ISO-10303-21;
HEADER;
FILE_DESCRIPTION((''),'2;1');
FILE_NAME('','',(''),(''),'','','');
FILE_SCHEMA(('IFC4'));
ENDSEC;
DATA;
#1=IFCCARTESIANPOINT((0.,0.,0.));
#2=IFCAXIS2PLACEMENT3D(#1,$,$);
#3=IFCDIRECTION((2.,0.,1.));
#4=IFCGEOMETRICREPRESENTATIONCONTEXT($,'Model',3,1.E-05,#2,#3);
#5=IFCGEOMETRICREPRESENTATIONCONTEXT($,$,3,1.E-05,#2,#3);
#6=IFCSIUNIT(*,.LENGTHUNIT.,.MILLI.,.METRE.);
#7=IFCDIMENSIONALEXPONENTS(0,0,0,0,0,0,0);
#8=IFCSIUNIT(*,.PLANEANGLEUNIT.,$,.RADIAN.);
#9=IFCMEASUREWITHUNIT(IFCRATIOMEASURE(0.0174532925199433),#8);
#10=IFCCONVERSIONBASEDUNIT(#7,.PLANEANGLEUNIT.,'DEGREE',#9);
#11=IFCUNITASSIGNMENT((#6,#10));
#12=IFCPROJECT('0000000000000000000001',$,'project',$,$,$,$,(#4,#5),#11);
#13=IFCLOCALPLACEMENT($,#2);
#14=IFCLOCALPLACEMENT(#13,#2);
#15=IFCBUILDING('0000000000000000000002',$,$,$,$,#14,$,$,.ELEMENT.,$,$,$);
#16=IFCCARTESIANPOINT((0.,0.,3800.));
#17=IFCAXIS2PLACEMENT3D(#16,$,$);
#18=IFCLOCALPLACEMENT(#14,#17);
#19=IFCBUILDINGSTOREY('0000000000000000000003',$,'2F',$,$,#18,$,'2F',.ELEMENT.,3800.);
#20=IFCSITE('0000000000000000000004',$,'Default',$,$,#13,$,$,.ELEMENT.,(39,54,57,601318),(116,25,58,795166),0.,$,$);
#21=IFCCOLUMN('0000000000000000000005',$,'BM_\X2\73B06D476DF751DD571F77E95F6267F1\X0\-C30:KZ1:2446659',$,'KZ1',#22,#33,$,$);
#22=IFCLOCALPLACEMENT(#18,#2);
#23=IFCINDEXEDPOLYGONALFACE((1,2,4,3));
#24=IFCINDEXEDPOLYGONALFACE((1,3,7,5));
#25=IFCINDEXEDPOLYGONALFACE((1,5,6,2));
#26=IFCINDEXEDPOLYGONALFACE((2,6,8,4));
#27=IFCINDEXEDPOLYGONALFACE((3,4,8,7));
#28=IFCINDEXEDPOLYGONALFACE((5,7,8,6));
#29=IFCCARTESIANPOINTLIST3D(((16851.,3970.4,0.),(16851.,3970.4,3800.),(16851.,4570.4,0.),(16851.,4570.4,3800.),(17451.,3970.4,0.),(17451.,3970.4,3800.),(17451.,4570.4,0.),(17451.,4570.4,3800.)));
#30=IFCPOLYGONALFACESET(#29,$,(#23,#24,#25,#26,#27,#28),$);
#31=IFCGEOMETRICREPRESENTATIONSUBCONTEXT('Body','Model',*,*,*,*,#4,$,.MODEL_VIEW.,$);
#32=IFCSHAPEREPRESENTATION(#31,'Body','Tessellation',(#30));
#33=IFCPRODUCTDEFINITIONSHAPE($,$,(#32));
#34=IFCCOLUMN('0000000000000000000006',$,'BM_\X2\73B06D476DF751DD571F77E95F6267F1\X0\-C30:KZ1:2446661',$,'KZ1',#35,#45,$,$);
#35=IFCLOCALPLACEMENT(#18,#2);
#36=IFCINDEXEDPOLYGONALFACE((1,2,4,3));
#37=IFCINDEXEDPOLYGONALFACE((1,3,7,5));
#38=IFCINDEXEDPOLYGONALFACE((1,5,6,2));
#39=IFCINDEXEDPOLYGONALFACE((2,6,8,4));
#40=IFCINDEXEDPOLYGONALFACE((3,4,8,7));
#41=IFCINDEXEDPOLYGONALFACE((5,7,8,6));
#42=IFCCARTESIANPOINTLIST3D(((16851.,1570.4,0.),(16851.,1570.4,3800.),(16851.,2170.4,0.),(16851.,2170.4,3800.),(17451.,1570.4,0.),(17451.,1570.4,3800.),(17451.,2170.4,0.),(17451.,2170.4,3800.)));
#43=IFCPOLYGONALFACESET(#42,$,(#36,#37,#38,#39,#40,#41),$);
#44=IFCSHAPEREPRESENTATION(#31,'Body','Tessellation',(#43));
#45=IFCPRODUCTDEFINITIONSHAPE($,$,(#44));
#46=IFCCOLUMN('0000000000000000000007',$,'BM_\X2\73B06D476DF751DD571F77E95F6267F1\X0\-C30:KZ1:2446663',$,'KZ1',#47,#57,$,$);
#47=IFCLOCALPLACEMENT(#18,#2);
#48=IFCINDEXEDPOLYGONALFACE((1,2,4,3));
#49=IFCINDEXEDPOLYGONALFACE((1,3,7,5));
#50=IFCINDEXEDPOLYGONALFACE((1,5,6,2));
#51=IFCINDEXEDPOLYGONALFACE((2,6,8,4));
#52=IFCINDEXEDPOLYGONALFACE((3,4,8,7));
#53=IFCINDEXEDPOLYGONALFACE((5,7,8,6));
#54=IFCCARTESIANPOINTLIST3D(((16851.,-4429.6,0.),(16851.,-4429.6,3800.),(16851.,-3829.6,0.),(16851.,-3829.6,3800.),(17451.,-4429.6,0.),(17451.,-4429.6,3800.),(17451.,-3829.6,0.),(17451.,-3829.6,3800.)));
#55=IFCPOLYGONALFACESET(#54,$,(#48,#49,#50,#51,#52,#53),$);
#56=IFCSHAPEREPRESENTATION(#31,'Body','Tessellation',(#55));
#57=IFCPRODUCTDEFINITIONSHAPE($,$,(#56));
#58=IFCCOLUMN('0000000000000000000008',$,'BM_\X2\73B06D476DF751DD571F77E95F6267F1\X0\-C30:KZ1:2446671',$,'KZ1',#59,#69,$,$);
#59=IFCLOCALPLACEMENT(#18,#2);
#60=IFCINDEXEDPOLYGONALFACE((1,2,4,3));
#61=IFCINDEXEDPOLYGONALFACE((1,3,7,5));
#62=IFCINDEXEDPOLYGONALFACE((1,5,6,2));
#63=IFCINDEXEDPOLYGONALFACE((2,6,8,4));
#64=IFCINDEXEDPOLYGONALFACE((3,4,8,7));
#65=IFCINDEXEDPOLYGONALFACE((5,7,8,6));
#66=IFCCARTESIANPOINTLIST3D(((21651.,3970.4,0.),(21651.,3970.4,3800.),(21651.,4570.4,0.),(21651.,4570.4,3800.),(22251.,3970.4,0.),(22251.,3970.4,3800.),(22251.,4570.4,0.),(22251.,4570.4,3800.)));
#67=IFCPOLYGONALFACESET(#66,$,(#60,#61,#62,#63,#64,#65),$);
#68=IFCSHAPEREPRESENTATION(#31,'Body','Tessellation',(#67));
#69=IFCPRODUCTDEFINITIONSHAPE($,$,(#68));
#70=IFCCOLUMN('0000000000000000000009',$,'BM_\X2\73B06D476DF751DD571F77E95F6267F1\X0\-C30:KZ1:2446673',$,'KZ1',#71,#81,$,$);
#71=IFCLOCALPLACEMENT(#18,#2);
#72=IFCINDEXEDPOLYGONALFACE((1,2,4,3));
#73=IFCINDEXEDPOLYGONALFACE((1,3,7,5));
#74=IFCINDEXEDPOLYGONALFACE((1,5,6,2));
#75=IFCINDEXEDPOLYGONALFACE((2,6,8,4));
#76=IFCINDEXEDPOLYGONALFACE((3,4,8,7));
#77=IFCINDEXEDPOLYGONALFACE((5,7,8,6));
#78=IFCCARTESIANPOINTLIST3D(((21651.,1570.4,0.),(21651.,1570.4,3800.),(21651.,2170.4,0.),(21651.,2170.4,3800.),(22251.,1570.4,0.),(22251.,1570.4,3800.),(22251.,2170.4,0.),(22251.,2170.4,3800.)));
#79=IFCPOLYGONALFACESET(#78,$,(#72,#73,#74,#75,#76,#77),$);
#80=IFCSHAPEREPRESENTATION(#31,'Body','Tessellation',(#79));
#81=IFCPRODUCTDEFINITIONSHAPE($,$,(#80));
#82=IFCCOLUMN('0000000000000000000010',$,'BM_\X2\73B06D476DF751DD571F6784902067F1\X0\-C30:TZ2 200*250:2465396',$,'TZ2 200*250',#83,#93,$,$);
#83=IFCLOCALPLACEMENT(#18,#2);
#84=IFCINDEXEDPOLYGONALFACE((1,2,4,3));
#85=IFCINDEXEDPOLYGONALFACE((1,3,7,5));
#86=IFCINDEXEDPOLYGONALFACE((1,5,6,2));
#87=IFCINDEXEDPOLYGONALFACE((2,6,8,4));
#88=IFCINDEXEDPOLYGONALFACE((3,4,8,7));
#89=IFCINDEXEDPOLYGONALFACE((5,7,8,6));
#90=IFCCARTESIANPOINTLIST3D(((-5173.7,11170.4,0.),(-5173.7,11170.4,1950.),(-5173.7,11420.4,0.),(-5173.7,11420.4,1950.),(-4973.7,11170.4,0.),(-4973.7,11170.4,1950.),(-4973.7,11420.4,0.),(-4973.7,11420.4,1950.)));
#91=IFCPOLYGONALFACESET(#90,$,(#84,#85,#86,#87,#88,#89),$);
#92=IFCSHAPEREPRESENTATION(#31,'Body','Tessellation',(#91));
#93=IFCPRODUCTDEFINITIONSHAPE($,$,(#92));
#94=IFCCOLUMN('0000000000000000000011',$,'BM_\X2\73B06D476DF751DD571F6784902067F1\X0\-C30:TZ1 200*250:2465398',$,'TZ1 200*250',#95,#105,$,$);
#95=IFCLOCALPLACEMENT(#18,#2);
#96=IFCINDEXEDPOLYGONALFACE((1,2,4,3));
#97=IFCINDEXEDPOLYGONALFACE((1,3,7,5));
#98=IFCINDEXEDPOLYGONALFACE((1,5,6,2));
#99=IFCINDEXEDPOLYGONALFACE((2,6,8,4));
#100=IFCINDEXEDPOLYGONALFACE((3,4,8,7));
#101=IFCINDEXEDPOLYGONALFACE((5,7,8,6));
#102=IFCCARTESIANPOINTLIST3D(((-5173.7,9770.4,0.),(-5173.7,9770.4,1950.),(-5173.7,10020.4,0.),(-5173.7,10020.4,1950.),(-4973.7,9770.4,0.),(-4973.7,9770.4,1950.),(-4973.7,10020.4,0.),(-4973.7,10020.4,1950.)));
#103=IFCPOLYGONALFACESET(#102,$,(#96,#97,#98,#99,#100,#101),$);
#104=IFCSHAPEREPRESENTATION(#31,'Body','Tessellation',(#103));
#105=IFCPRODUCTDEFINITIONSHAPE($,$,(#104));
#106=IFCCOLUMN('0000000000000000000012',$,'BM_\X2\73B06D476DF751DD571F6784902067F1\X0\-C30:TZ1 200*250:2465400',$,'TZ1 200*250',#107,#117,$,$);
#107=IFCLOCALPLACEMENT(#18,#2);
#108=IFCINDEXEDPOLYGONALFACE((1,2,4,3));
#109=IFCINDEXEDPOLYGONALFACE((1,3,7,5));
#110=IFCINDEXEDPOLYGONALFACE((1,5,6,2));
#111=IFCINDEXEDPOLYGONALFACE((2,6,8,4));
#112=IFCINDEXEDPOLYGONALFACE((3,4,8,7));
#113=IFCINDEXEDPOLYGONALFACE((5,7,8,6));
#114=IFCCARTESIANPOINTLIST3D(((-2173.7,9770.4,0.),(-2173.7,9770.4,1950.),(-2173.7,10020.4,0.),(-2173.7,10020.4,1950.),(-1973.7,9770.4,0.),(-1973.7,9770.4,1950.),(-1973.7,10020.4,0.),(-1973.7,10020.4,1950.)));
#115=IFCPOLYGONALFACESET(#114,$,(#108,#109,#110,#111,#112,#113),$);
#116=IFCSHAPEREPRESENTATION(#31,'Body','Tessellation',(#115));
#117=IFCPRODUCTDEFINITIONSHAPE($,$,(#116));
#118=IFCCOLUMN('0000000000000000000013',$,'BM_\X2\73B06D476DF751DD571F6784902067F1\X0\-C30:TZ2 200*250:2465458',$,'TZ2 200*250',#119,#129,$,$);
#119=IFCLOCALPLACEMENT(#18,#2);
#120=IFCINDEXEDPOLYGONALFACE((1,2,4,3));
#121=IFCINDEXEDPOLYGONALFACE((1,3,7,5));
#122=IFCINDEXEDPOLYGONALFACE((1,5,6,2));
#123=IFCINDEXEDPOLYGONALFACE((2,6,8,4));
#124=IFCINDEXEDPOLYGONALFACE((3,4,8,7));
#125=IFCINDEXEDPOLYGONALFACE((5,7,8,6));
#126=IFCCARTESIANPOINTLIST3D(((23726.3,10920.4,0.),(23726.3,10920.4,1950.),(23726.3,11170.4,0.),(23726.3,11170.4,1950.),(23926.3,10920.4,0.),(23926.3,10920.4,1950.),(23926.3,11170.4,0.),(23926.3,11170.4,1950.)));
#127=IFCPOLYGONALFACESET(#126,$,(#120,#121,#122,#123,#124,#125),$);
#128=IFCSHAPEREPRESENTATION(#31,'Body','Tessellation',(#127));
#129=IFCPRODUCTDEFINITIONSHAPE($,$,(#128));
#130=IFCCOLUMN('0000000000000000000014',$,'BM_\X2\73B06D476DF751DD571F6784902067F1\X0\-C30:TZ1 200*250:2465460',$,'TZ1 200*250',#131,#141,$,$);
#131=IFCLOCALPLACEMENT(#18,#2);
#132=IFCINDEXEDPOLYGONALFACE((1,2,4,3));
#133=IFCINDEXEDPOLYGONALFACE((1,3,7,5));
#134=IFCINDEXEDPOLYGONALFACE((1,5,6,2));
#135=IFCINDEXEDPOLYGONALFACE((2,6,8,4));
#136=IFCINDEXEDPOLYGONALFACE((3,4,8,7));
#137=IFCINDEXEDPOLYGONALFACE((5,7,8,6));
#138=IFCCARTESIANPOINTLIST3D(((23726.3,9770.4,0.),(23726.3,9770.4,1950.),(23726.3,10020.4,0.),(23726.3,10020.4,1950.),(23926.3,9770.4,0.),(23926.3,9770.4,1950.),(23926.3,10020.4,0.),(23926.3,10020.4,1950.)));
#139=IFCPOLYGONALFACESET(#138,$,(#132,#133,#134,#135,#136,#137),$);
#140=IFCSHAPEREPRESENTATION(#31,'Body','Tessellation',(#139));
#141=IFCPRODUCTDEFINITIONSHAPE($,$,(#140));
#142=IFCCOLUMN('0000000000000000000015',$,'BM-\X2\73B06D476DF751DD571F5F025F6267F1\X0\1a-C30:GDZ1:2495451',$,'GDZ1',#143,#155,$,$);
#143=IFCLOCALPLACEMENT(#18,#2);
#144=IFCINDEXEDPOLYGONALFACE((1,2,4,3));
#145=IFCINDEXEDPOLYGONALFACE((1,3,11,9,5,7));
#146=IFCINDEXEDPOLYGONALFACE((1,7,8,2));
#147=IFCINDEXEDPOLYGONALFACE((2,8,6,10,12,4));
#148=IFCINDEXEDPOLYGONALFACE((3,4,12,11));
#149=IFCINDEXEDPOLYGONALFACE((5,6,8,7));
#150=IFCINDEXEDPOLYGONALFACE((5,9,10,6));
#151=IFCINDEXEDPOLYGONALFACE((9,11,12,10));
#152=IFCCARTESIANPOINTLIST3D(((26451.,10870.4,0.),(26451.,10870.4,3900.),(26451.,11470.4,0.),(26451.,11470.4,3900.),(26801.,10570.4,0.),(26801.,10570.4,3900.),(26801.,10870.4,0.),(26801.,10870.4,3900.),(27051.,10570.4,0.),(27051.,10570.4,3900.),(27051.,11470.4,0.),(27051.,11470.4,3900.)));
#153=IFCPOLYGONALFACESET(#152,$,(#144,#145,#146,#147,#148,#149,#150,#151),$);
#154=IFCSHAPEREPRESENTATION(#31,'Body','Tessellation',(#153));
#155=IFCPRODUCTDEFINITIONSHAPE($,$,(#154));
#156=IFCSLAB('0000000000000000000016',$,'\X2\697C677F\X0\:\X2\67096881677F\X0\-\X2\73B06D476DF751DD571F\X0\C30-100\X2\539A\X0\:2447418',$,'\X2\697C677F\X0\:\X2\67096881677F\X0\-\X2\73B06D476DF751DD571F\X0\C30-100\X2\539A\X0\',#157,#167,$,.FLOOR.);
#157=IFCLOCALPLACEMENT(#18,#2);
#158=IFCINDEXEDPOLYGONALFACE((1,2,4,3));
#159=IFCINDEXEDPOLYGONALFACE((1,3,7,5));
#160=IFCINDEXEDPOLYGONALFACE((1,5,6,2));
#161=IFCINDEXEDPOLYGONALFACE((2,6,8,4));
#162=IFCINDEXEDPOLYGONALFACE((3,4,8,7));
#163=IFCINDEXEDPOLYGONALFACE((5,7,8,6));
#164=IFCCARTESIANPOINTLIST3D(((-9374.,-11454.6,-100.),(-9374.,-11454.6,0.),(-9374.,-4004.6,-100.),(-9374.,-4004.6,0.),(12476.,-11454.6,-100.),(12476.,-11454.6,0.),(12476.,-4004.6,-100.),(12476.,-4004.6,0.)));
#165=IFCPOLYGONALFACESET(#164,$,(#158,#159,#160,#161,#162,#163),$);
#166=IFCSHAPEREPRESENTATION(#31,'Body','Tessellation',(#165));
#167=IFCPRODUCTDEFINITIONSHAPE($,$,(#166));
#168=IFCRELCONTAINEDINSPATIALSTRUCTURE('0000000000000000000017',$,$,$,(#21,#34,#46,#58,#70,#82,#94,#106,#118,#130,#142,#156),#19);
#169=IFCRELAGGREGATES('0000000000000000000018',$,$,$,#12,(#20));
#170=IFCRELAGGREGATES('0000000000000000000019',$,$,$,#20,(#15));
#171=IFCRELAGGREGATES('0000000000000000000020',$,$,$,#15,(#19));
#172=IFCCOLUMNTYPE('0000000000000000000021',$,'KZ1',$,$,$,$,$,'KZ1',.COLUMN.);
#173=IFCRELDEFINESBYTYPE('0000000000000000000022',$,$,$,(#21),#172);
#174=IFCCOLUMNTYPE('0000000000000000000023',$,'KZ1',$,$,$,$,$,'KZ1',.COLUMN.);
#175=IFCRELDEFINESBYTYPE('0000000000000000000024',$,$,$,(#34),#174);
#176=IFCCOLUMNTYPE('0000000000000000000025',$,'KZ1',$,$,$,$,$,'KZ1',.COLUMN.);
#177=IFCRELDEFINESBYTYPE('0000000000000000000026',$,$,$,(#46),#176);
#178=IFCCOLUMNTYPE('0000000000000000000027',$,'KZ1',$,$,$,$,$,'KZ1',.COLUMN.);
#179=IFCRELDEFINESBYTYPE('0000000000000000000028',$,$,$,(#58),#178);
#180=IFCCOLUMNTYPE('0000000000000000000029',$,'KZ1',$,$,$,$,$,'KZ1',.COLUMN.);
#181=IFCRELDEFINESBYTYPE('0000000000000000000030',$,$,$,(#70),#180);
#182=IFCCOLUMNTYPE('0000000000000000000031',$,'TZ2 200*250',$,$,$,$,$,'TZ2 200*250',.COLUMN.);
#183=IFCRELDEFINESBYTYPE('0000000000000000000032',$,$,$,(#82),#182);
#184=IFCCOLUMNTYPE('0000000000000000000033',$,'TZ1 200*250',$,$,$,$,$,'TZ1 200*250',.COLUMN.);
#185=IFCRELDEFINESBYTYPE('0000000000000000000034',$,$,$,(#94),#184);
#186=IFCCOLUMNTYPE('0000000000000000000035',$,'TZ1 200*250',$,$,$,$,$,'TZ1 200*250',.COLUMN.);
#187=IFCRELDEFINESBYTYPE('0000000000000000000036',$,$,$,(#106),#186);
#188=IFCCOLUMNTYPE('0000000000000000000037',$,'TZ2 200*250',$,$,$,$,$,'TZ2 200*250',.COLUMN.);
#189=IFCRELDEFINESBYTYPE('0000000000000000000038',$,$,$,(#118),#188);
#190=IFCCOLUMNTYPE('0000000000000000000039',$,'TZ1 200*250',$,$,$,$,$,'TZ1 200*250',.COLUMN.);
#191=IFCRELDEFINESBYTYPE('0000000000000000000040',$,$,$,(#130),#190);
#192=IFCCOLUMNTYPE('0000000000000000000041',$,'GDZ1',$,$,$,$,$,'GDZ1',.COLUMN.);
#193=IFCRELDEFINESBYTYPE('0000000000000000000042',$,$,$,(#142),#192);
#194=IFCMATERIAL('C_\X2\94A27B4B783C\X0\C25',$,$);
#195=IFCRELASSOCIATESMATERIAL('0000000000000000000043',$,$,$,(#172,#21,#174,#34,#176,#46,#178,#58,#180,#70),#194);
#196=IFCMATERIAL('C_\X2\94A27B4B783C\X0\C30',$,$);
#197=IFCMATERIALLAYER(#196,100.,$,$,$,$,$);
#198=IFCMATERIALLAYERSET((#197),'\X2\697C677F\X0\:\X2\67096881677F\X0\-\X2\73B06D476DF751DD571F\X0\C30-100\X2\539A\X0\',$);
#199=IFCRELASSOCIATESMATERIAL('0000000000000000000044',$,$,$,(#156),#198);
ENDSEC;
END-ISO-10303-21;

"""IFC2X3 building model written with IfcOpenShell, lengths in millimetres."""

from ifc_helpers import new_model, entity, si_unit, converted_unit, direction, frame, frame_2d, origin, place, context, subcontext, project, spatial, polyline, rectangle, outline, extrude, source, transform, mapped, material, layer, layer_set, layer_usage, type_object, type_shapes, element, save


model = new_model("IFC2X3")

# Units and contexts
model_context = context("Model", 3, precision=1e-05, world=origin(), true_north=direction((2.0, 0.0, 1.0)))
context_of_model = context(None, 3, precision=1e-05, world=origin(), true_north=direction((2.0, 0.0, 1.0)))
body_context = subcontext(model_context, "Body", "Model", "MODEL_VIEW")
ifc_project = project(units=[si_unit("LENGTHUNIT", "METRE", prefix="MILLI"), converted_unit("PLANEANGLEUNIT", "DEGREE", entity("IfcRatioMeasure", 0.0174532925199433), si_unit("PLANEANGLEUNIT", "RADIAN"), dimensions=[0, 0, 0, 0, 0, 0, 0])], contexts=[model_context, context_of_model])

# Site, building, storey
site_placement = place(None, origin())
site = spatial("IfcSite", under=ifc_project, at=site_placement, Name="Default", CompositionType="ELEMENT", RefLatitude=(39, 54, 57, 601318), RefLongitude=(116, 25, 58, 795166), RefElevation=0.0)
building_placement = place(site_placement, origin())
building = spatial("IfcBuilding", under=site, at=building_placement, CompositionType="ELEMENT")
storey_placement = place(building_placement, frame((0.0, 0.0, 3800.0)))
storey = spatial("IfcBuildingStorey", under=building, at=storey_placement, Name="2F", LongName="2F", CompositionType="ELEMENT", Elevation=3800.0)

# Columns
ifc_material_1 = material(Name="C_钢筋砼C25")
column_type_1 = type_object("IfcColumnType", Name="KZ1", ElementType="KZ1", PredefinedType="COLUMN", material=ifc_material_1)
shared_shape_1 = source(origin(), body_context, "Body", "SweptSolid", [
    extrude(rectangle(XDim=600.0, YDim=600.0, at=frame_2d((0.0, 0.0), x_axis=(1.0, 0.0))), frame((17151.0, 4270.4, 3800.0), z_axis=(0.0, 0.0, 1.0), x_axis=(-1.0, 0.0, 0.0)), (0.0, 0.0, 1.0), 3800.0),
])
type_shapes(column_type_1, [shared_shape_1])
column_1_placement = place(storey_placement, frame((0.0, 0.0, -3800.0)))
element("IfcColumn", 1, at=column_1_placement, inside=storey, type_object=column_type_1, material=ifc_material_1, Name="BM_现浇混凝土矩形柱-C30:KZ1:2446659", ObjectType="KZ1", context=body_context, shape_type="MappedRepresentation", body=[
    mapped(shared_shape_1, transform((0.0, 0.0, 0.0), scale=1.0)),
])
column_type_2 = type_object("IfcColumnType", Name="KZ1", ElementType="KZ1", PredefinedType="COLUMN", material=ifc_material_1)
shared_shape_2 = source(origin(), body_context, "Body", "SweptSolid", [
    extrude(rectangle(XDim=600.0, YDim=600.0, at=frame_2d((0.0, 0.0), x_axis=(1.0, 0.0))), frame((17151.0, 1870.4, 3800.0), z_axis=(0.0, 0.0, 1.0), x_axis=(-1.0, 0.0, 0.0)), (0.0, 0.0, 1.0), 3800.0),
])
type_shapes(column_type_2, [shared_shape_2])
column_2_placement = place(storey_placement, frame((0.0, 0.0, -3800.0)))
element("IfcColumn", 2, at=column_2_placement, inside=storey, type_object=column_type_2, material=ifc_material_1, Name="BM_现浇混凝土矩形柱-C30:KZ1:2446661", ObjectType="KZ1", context=body_context, shape_type="MappedRepresentation", body=[
    mapped(shared_shape_2, transform((0.0, 0.0, 0.0), scale=1.0)),
])
column_type_3 = type_object("IfcColumnType", Name="KZ1", ElementType="KZ1", PredefinedType="COLUMN", material=ifc_material_1)
shared_shape_3 = source(origin(), body_context, "Body", "SweptSolid", [
    extrude(rectangle(XDim=600.0, YDim=600.0, at=frame_2d((0.0, 0.0), x_axis=(1.0, 0.0))), frame((17151.0, -4129.6, 3800.0), z_axis=(0.0, 0.0, 1.0), x_axis=(-1.0, 0.0, 0.0)), (0.0, 0.0, 1.0), 3800.0),
])
type_shapes(column_type_3, [shared_shape_3])
column_3_placement = place(storey_placement, frame((0.0, 0.0, -3800.0)))
element("IfcColumn", 3, at=column_3_placement, inside=storey, type_object=column_type_3, material=ifc_material_1, Name="BM_现浇混凝土矩形柱-C30:KZ1:2446663", ObjectType="KZ1", context=body_context, shape_type="MappedRepresentation", body=[
    mapped(shared_shape_3, transform((0.0, 0.0, 0.0), scale=1.0)),
])
column_type_4 = type_object("IfcColumnType", Name="KZ1", ElementType="KZ1", PredefinedType="COLUMN", material=ifc_material_1)
shared_shape_4 = source(origin(), body_context, "Body", "SweptSolid", [
    extrude(rectangle(XDim=600.0, YDim=600.0, at=frame_2d((0.0, 0.0), x_axis=(1.0, 0.0))), frame((21951.0, 4270.4, 3800.0), z_axis=(0.0, 0.0, 1.0), x_axis=(-1.0, 0.0, 0.0)), (0.0, 0.0, 1.0), 3800.0),
])
type_shapes(column_type_4, [shared_shape_4])
column_4_placement = place(storey_placement, frame((0.0, 0.0, -3800.0)))
element("IfcColumn", 4, at=column_4_placement, inside=storey, type_object=column_type_4, material=ifc_material_1, Name="BM_现浇混凝土矩形柱-C30:KZ1:2446671", ObjectType="KZ1", context=body_context, shape_type="MappedRepresentation", body=[
    mapped(shared_shape_4, transform((0.0, 0.0, 0.0), scale=1.0)),
])
column_type_5 = type_object("IfcColumnType", Name="KZ1", ElementType="KZ1", PredefinedType="COLUMN", material=ifc_material_1)
shared_shape_5 = source(origin(), body_context, "Body", "SweptSolid", [
    extrude(rectangle(XDim=600.0, YDim=600.0, at=frame_2d((0.0, 0.0), x_axis=(1.0, 0.0))), frame((21951.0, 1870.4, 3800.0), z_axis=(0.0, 0.0, 1.0), x_axis=(-1.0, 0.0, 0.0)), (0.0, 0.0, 1.0), 3800.0),
])
type_shapes(column_type_5, [shared_shape_5])
column_5_placement = place(storey_placement, frame((0.0, 0.0, -3800.0)))
element("IfcColumn", 5, at=column_5_placement, inside=storey, type_object=column_type_5, material=ifc_material_1, Name="BM_现浇混凝土矩形柱-C30:KZ1:2446673", ObjectType="KZ1", context=body_context, shape_type="MappedRepresentation", body=[
    mapped(shared_shape_5, transform((0.0, 0.0, 0.0), scale=1.0)),
])
column_type_6 = type_object("IfcColumnType", Name="TZ2 200*250", ElementType="TZ2 200*250", PredefinedType="COLUMN")
shared_shape_6 = source(origin(), body_context, "Body", "SweptSolid", [
    extrude(rectangle(XDim=250.0, YDim=200.0, at=frame_2d((-5073.7, 11295.4), x_axis=(0.0, -1.0))), origin(), (0.0, 0.0, 1.0), 1950.0),
])
type_shapes(column_type_6, [shared_shape_6])
column_6_placement = place(storey_placement, origin())
element("IfcColumn", 6, at=column_6_placement, inside=storey, type_object=column_type_6, Name="BM_现浇混凝土构造柱-C30:TZ2 200*250:2465396", ObjectType="TZ2 200*250", context=body_context, shape_type="MappedRepresentation", body=[
    mapped(shared_shape_6, transform((0.0, 0.0, 0.0), scale=1.0)),
])
column_type_7 = type_object("IfcColumnType", Name="TZ1 200*250", ElementType="TZ1 200*250", PredefinedType="COLUMN")
shared_shape_7 = source(origin(), body_context, "Body", "SweptSolid", [
    extrude(rectangle(XDim=250.0, YDim=200.0, at=frame_2d((-5073.7, 9895.4), x_axis=(0.0, -1.0))), origin(), (0.0, 0.0, 1.0), 1950.0),
])
type_shapes(column_type_7, [shared_shape_7])
column_7_placement = place(storey_placement, origin())
element("IfcColumn", 7, at=column_7_placement, inside=storey, type_object=column_type_7, Name="BM_现浇混凝土构造柱-C30:TZ1 200*250:2465398", ObjectType="TZ1 200*250", context=body_context, shape_type="MappedRepresentation", body=[
    mapped(shared_shape_7, transform((0.0, 0.0, 0.0), scale=1.0)),
])
column_type_8 = type_object("IfcColumnType", Name="TZ1 200*250", ElementType="TZ1 200*250", PredefinedType="COLUMN")
shared_shape_8 = source(origin(), body_context, "Body", "SweptSolid", [
    extrude(rectangle(XDim=250.0, YDim=200.0, at=frame_2d((-2073.7, 9895.4), x_axis=(0.0, -1.0))), origin(), (0.0, 0.0, 1.0), 1950.0),
])
type_shapes(column_type_8, [shared_shape_8])
column_8_placement = place(storey_placement, origin())
element("IfcColumn", 8, at=column_8_placement, inside=storey, type_object=column_type_8, Name="BM_现浇混凝土构造柱-C30:TZ1 200*250:2465400", ObjectType="TZ1 200*250", context=body_context, shape_type="MappedRepresentation", body=[
    mapped(shared_shape_8, transform((0.0, 0.0, 0.0), scale=1.0)),
])
column_type_9 = type_object("IfcColumnType", Name="TZ2 200*250", ElementType="TZ2 200*250", PredefinedType="COLUMN")
shared_shape_9 = source(origin(), body_context, "Body", "SweptSolid", [
    extrude(rectangle(XDim=250.0, YDim=200.0, at=frame_2d((23826.3, 11045.4), x_axis=(0.0, -1.0))), origin(), (0.0, 0.0, 1.0), 1950.0),
])
type_shapes(column_type_9, [shared_shape_9])
column_9_placement = place(storey_placement, origin())
element("IfcColumn", 9, at=column_9_placement, inside=storey, type_object=column_type_9, Name="BM_现浇混凝土构造柱-C30:TZ2 200*250:2465458", ObjectType="TZ2 200*250", context=body_context, shape_type="MappedRepresentation", body=[
    mapped(shared_shape_9, transform((0.0, 0.0, 0.0), scale=1.0)),
])
column_type_10 = type_object("IfcColumnType", Name="TZ1 200*250", ElementType="TZ1 200*250", PredefinedType="COLUMN")
shared_shape_10 = source(origin(), body_context, "Body", "SweptSolid", [
    extrude(rectangle(XDim=250.0, YDim=200.0, at=frame_2d((23826.3, 9895.4), x_axis=(0.0, -1.0))), origin(), (0.0, 0.0, 1.0), 1950.0),
])
type_shapes(column_type_10, [shared_shape_10])
column_10_placement = place(storey_placement, origin())
element("IfcColumn", 10, at=column_10_placement, inside=storey, type_object=column_type_10, Name="BM_现浇混凝土构造柱-C30:TZ1 200*250:2465460", ObjectType="TZ1 200*250", context=body_context, shape_type="MappedRepresentation", body=[
    mapped(shared_shape_10, transform((0.0, 0.0, 0.0), scale=1.0)),
])
column_type_11 = type_object("IfcColumnType", Name="GDZ1", ElementType="GDZ1", PredefinedType="COLUMN")
shared_shape_11 = source(origin(), body_context, "Body", "SweptSolid", [
    extrude(outline(polyline([(27051.0, 10570.4), (27051.0, 11470.4), (26451.0, 11470.4), (26451.0, 10870.4), (26801.0, 10870.4), (26801.0, 10570.4), (27051.0, 10570.4)])), origin(), (0.0, 0.0, 1.0), 3900.0),
])
type_shapes(column_type_11, [shared_shape_11])
column_11_placement = place(storey_placement, origin())
element("IfcColumn", 11, at=column_11_placement, inside=storey, type_object=column_type_11, Name="BM-现浇混凝土异形柱1a-C30:GDZ1:2495451", ObjectType="GDZ1", context=body_context, shape_type="MappedRepresentation", body=[
    mapped(shared_shape_11, transform((0.0, 0.0, 0.0), scale=1.0)),
])

# Slab
ifc_material_2 = material(Name="C_钢筋砼C30")
ifc_layer_1 = layer(ifc_material_2, 100.0)
ifc_layer_set_1 = layer_set([ifc_layer_1], Name="楼板:有梁板-现浇混凝土C30-100厚")
ifc_layer_usage_1 = layer_usage(ifc_layer_set_1, "AXIS3", "POSITIVE", 0.0)
slab_1_placement = place(storey_placement, origin())
element("IfcSlab", 12, at=slab_1_placement, inside=storey, material=ifc_layer_usage_1, Name="楼板:有梁板-现浇混凝土C30-100厚:2447418", ObjectType="楼板:有梁板-现浇混凝土C30-100厚", PredefinedType="FLOOR", context=body_context, shape_type="SweptSolid", body=[
    extrude(rectangle(XDim=7450.0, YDim=21850.0, at=frame_2d((0.0, 0.0), x_axis=(1.0, 0.0))), frame((1551.0, -7729.6, 0.0), z_axis=(0.0, 0.0, -1.0), x_axis=(0.0, 1.0, 0.0)), (0.0, 0.0, 1.0), 100.0),
])

save(model, "model.ifc")
